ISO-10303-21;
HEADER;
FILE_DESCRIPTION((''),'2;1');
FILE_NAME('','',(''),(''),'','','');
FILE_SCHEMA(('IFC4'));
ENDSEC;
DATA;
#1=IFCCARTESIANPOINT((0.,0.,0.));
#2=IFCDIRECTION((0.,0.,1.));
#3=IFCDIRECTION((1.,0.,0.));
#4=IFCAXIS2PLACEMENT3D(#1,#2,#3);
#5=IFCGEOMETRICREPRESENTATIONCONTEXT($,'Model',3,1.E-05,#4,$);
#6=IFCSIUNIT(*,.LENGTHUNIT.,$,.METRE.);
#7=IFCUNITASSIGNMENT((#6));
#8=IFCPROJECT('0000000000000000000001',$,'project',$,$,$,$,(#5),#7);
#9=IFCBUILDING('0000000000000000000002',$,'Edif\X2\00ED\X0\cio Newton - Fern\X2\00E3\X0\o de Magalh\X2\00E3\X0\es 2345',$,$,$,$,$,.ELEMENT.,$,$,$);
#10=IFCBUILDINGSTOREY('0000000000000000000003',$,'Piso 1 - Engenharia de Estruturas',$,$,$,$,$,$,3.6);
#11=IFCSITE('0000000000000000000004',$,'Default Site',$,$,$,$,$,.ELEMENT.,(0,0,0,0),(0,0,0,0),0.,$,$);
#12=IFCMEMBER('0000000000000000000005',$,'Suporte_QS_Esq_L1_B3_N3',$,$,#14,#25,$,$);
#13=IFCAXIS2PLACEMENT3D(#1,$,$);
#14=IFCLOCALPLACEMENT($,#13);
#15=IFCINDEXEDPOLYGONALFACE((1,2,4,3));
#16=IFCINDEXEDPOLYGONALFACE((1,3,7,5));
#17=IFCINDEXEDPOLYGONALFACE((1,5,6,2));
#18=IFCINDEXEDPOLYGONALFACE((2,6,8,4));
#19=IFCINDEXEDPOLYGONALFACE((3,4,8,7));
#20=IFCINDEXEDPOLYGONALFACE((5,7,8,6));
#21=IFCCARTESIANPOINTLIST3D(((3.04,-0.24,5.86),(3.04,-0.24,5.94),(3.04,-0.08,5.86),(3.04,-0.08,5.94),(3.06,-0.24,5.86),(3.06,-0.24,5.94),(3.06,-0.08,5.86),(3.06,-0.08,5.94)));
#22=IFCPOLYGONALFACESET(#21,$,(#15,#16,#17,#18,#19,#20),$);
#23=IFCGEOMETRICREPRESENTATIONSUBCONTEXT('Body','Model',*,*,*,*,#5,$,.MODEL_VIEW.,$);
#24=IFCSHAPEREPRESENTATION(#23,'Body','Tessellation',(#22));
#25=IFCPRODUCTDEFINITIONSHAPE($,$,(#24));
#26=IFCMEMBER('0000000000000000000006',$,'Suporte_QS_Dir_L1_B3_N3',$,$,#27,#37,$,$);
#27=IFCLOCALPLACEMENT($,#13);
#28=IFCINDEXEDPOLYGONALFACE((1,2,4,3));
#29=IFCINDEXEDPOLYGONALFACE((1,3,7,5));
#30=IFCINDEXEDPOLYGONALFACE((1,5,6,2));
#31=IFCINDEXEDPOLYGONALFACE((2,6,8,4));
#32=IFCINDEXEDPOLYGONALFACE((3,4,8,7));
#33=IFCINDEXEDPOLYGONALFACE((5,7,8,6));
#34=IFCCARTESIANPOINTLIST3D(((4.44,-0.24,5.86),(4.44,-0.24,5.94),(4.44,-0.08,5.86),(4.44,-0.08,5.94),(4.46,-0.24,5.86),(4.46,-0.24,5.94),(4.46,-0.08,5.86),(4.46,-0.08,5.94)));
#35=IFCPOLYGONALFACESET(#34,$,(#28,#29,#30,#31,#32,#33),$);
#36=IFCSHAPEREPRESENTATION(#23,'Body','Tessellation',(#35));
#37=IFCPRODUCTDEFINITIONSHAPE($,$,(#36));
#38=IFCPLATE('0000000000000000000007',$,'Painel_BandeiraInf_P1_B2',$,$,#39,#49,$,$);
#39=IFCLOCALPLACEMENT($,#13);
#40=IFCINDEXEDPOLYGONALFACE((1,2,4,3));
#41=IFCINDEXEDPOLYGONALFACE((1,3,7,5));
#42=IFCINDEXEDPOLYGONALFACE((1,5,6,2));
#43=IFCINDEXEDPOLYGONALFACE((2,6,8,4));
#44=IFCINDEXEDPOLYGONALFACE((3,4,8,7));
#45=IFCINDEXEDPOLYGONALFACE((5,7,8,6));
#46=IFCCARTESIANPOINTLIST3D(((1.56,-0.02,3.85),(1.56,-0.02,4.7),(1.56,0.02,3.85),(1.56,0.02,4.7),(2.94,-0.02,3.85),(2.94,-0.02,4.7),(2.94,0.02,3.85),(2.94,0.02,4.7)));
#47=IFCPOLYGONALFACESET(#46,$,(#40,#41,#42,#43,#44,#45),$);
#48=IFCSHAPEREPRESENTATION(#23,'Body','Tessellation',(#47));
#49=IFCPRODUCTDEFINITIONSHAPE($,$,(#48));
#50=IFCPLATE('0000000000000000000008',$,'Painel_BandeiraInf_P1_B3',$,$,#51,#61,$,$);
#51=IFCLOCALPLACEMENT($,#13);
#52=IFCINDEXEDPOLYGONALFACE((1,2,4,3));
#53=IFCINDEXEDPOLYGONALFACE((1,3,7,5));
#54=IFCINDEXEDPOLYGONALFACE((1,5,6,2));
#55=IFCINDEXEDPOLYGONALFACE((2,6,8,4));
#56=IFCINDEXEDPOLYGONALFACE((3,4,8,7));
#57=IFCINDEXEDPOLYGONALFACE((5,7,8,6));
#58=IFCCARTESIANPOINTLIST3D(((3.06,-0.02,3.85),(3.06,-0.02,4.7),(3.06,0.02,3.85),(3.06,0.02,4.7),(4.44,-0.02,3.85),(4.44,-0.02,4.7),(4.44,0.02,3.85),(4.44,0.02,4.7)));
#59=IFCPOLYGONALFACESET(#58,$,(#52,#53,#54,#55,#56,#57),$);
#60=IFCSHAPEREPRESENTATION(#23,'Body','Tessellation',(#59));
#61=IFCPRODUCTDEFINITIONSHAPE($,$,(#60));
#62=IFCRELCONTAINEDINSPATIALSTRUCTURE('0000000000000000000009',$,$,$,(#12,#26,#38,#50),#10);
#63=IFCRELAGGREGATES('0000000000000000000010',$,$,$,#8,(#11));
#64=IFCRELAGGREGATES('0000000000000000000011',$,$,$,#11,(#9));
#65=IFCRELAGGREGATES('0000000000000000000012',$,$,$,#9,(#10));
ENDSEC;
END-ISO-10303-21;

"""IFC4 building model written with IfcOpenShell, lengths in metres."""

from ifc_helpers import new_model, si_unit, frame, frame_2d, origin_with_axes, place, context, subcontext, project, spatial, rectangle, extrude, element, save


model = new_model("IFC4")

# Units and contexts
model_context = context("Model", 3, precision=1e-05, world=origin_with_axes())
body_context = subcontext(model_context, "Body", "Model", "MODEL_VIEW")
ifc_project = project(units=[si_unit("LENGTHUNIT", "METRE")], contexts=[model_context])

# Site, building, storey
site = spatial("IfcSite", under=ifc_project, Name="Default Site", CompositionType="ELEMENT", RefLatitude=(0, 0, 0, 0), RefLongitude=(0, 0, 0, 0), RefElevation=0.0)
building = spatial("IfcBuilding", under=site, Name="Edifício Newton - Fernão de Magalhães 2345", CompositionType="ELEMENT")
storey = spatial("IfcBuildingStorey", under=building, Name="Piso 1 - Engenharia de Estruturas", Elevation=3.6)

# Members
for number, where, z_axis, x_axis, name in (
    (1, (3.04, -0.24, 5.86), (0.0, 0.0, 1.0), (1.0, 0.0, 0.0), "Suporte_QS_Esq_L1_B3_N3"),
    (2, (4.44, -0.24, 5.86), (0.0, 0.0, 1.0), (1.0, 0.0, 0.0), "Suporte_QS_Dir_L1_B3_N3"),
):
    element("IfcMember", number, at=place(None, frame(where, z_axis=z_axis, x_axis=x_axis)), inside=storey, Name=name, context=body_context, shape_type="SweptSolid", body=[
        extrude(rectangle(XDim=0.02, YDim=0.16, at=frame_2d((0.01, 0.08))), origin_with_axes(), (0.0, 0.0, 1.0), 0.08),
    ])

# Plates
for number, where, z_axis, x_axis, name in (
    (3, (1.56, -0.02, 3.85), (0.0, 0.0, 1.0), (1.0, 0.0, 0.0), "Painel_BandeiraInf_P1_B2"),
    (4, (3.06, -0.02, 3.85), (0.0, 0.0, 1.0), (1.0, 0.0, 0.0), "Painel_BandeiraInf_P1_B3"),
):
    element("IfcPlate", number, at=place(None, frame(where, z_axis=z_axis, x_axis=x_axis)), inside=storey, Name=name, context=body_context, shape_type="SweptSolid", body=[
        extrude(rectangle(XDim=1.38, YDim=0.04, at=frame_2d((0.69, 0.02))), origin_with_axes(), (0.0, 0.0, 1.0), 0.85),
    ])

save(model, "model.ifc")
